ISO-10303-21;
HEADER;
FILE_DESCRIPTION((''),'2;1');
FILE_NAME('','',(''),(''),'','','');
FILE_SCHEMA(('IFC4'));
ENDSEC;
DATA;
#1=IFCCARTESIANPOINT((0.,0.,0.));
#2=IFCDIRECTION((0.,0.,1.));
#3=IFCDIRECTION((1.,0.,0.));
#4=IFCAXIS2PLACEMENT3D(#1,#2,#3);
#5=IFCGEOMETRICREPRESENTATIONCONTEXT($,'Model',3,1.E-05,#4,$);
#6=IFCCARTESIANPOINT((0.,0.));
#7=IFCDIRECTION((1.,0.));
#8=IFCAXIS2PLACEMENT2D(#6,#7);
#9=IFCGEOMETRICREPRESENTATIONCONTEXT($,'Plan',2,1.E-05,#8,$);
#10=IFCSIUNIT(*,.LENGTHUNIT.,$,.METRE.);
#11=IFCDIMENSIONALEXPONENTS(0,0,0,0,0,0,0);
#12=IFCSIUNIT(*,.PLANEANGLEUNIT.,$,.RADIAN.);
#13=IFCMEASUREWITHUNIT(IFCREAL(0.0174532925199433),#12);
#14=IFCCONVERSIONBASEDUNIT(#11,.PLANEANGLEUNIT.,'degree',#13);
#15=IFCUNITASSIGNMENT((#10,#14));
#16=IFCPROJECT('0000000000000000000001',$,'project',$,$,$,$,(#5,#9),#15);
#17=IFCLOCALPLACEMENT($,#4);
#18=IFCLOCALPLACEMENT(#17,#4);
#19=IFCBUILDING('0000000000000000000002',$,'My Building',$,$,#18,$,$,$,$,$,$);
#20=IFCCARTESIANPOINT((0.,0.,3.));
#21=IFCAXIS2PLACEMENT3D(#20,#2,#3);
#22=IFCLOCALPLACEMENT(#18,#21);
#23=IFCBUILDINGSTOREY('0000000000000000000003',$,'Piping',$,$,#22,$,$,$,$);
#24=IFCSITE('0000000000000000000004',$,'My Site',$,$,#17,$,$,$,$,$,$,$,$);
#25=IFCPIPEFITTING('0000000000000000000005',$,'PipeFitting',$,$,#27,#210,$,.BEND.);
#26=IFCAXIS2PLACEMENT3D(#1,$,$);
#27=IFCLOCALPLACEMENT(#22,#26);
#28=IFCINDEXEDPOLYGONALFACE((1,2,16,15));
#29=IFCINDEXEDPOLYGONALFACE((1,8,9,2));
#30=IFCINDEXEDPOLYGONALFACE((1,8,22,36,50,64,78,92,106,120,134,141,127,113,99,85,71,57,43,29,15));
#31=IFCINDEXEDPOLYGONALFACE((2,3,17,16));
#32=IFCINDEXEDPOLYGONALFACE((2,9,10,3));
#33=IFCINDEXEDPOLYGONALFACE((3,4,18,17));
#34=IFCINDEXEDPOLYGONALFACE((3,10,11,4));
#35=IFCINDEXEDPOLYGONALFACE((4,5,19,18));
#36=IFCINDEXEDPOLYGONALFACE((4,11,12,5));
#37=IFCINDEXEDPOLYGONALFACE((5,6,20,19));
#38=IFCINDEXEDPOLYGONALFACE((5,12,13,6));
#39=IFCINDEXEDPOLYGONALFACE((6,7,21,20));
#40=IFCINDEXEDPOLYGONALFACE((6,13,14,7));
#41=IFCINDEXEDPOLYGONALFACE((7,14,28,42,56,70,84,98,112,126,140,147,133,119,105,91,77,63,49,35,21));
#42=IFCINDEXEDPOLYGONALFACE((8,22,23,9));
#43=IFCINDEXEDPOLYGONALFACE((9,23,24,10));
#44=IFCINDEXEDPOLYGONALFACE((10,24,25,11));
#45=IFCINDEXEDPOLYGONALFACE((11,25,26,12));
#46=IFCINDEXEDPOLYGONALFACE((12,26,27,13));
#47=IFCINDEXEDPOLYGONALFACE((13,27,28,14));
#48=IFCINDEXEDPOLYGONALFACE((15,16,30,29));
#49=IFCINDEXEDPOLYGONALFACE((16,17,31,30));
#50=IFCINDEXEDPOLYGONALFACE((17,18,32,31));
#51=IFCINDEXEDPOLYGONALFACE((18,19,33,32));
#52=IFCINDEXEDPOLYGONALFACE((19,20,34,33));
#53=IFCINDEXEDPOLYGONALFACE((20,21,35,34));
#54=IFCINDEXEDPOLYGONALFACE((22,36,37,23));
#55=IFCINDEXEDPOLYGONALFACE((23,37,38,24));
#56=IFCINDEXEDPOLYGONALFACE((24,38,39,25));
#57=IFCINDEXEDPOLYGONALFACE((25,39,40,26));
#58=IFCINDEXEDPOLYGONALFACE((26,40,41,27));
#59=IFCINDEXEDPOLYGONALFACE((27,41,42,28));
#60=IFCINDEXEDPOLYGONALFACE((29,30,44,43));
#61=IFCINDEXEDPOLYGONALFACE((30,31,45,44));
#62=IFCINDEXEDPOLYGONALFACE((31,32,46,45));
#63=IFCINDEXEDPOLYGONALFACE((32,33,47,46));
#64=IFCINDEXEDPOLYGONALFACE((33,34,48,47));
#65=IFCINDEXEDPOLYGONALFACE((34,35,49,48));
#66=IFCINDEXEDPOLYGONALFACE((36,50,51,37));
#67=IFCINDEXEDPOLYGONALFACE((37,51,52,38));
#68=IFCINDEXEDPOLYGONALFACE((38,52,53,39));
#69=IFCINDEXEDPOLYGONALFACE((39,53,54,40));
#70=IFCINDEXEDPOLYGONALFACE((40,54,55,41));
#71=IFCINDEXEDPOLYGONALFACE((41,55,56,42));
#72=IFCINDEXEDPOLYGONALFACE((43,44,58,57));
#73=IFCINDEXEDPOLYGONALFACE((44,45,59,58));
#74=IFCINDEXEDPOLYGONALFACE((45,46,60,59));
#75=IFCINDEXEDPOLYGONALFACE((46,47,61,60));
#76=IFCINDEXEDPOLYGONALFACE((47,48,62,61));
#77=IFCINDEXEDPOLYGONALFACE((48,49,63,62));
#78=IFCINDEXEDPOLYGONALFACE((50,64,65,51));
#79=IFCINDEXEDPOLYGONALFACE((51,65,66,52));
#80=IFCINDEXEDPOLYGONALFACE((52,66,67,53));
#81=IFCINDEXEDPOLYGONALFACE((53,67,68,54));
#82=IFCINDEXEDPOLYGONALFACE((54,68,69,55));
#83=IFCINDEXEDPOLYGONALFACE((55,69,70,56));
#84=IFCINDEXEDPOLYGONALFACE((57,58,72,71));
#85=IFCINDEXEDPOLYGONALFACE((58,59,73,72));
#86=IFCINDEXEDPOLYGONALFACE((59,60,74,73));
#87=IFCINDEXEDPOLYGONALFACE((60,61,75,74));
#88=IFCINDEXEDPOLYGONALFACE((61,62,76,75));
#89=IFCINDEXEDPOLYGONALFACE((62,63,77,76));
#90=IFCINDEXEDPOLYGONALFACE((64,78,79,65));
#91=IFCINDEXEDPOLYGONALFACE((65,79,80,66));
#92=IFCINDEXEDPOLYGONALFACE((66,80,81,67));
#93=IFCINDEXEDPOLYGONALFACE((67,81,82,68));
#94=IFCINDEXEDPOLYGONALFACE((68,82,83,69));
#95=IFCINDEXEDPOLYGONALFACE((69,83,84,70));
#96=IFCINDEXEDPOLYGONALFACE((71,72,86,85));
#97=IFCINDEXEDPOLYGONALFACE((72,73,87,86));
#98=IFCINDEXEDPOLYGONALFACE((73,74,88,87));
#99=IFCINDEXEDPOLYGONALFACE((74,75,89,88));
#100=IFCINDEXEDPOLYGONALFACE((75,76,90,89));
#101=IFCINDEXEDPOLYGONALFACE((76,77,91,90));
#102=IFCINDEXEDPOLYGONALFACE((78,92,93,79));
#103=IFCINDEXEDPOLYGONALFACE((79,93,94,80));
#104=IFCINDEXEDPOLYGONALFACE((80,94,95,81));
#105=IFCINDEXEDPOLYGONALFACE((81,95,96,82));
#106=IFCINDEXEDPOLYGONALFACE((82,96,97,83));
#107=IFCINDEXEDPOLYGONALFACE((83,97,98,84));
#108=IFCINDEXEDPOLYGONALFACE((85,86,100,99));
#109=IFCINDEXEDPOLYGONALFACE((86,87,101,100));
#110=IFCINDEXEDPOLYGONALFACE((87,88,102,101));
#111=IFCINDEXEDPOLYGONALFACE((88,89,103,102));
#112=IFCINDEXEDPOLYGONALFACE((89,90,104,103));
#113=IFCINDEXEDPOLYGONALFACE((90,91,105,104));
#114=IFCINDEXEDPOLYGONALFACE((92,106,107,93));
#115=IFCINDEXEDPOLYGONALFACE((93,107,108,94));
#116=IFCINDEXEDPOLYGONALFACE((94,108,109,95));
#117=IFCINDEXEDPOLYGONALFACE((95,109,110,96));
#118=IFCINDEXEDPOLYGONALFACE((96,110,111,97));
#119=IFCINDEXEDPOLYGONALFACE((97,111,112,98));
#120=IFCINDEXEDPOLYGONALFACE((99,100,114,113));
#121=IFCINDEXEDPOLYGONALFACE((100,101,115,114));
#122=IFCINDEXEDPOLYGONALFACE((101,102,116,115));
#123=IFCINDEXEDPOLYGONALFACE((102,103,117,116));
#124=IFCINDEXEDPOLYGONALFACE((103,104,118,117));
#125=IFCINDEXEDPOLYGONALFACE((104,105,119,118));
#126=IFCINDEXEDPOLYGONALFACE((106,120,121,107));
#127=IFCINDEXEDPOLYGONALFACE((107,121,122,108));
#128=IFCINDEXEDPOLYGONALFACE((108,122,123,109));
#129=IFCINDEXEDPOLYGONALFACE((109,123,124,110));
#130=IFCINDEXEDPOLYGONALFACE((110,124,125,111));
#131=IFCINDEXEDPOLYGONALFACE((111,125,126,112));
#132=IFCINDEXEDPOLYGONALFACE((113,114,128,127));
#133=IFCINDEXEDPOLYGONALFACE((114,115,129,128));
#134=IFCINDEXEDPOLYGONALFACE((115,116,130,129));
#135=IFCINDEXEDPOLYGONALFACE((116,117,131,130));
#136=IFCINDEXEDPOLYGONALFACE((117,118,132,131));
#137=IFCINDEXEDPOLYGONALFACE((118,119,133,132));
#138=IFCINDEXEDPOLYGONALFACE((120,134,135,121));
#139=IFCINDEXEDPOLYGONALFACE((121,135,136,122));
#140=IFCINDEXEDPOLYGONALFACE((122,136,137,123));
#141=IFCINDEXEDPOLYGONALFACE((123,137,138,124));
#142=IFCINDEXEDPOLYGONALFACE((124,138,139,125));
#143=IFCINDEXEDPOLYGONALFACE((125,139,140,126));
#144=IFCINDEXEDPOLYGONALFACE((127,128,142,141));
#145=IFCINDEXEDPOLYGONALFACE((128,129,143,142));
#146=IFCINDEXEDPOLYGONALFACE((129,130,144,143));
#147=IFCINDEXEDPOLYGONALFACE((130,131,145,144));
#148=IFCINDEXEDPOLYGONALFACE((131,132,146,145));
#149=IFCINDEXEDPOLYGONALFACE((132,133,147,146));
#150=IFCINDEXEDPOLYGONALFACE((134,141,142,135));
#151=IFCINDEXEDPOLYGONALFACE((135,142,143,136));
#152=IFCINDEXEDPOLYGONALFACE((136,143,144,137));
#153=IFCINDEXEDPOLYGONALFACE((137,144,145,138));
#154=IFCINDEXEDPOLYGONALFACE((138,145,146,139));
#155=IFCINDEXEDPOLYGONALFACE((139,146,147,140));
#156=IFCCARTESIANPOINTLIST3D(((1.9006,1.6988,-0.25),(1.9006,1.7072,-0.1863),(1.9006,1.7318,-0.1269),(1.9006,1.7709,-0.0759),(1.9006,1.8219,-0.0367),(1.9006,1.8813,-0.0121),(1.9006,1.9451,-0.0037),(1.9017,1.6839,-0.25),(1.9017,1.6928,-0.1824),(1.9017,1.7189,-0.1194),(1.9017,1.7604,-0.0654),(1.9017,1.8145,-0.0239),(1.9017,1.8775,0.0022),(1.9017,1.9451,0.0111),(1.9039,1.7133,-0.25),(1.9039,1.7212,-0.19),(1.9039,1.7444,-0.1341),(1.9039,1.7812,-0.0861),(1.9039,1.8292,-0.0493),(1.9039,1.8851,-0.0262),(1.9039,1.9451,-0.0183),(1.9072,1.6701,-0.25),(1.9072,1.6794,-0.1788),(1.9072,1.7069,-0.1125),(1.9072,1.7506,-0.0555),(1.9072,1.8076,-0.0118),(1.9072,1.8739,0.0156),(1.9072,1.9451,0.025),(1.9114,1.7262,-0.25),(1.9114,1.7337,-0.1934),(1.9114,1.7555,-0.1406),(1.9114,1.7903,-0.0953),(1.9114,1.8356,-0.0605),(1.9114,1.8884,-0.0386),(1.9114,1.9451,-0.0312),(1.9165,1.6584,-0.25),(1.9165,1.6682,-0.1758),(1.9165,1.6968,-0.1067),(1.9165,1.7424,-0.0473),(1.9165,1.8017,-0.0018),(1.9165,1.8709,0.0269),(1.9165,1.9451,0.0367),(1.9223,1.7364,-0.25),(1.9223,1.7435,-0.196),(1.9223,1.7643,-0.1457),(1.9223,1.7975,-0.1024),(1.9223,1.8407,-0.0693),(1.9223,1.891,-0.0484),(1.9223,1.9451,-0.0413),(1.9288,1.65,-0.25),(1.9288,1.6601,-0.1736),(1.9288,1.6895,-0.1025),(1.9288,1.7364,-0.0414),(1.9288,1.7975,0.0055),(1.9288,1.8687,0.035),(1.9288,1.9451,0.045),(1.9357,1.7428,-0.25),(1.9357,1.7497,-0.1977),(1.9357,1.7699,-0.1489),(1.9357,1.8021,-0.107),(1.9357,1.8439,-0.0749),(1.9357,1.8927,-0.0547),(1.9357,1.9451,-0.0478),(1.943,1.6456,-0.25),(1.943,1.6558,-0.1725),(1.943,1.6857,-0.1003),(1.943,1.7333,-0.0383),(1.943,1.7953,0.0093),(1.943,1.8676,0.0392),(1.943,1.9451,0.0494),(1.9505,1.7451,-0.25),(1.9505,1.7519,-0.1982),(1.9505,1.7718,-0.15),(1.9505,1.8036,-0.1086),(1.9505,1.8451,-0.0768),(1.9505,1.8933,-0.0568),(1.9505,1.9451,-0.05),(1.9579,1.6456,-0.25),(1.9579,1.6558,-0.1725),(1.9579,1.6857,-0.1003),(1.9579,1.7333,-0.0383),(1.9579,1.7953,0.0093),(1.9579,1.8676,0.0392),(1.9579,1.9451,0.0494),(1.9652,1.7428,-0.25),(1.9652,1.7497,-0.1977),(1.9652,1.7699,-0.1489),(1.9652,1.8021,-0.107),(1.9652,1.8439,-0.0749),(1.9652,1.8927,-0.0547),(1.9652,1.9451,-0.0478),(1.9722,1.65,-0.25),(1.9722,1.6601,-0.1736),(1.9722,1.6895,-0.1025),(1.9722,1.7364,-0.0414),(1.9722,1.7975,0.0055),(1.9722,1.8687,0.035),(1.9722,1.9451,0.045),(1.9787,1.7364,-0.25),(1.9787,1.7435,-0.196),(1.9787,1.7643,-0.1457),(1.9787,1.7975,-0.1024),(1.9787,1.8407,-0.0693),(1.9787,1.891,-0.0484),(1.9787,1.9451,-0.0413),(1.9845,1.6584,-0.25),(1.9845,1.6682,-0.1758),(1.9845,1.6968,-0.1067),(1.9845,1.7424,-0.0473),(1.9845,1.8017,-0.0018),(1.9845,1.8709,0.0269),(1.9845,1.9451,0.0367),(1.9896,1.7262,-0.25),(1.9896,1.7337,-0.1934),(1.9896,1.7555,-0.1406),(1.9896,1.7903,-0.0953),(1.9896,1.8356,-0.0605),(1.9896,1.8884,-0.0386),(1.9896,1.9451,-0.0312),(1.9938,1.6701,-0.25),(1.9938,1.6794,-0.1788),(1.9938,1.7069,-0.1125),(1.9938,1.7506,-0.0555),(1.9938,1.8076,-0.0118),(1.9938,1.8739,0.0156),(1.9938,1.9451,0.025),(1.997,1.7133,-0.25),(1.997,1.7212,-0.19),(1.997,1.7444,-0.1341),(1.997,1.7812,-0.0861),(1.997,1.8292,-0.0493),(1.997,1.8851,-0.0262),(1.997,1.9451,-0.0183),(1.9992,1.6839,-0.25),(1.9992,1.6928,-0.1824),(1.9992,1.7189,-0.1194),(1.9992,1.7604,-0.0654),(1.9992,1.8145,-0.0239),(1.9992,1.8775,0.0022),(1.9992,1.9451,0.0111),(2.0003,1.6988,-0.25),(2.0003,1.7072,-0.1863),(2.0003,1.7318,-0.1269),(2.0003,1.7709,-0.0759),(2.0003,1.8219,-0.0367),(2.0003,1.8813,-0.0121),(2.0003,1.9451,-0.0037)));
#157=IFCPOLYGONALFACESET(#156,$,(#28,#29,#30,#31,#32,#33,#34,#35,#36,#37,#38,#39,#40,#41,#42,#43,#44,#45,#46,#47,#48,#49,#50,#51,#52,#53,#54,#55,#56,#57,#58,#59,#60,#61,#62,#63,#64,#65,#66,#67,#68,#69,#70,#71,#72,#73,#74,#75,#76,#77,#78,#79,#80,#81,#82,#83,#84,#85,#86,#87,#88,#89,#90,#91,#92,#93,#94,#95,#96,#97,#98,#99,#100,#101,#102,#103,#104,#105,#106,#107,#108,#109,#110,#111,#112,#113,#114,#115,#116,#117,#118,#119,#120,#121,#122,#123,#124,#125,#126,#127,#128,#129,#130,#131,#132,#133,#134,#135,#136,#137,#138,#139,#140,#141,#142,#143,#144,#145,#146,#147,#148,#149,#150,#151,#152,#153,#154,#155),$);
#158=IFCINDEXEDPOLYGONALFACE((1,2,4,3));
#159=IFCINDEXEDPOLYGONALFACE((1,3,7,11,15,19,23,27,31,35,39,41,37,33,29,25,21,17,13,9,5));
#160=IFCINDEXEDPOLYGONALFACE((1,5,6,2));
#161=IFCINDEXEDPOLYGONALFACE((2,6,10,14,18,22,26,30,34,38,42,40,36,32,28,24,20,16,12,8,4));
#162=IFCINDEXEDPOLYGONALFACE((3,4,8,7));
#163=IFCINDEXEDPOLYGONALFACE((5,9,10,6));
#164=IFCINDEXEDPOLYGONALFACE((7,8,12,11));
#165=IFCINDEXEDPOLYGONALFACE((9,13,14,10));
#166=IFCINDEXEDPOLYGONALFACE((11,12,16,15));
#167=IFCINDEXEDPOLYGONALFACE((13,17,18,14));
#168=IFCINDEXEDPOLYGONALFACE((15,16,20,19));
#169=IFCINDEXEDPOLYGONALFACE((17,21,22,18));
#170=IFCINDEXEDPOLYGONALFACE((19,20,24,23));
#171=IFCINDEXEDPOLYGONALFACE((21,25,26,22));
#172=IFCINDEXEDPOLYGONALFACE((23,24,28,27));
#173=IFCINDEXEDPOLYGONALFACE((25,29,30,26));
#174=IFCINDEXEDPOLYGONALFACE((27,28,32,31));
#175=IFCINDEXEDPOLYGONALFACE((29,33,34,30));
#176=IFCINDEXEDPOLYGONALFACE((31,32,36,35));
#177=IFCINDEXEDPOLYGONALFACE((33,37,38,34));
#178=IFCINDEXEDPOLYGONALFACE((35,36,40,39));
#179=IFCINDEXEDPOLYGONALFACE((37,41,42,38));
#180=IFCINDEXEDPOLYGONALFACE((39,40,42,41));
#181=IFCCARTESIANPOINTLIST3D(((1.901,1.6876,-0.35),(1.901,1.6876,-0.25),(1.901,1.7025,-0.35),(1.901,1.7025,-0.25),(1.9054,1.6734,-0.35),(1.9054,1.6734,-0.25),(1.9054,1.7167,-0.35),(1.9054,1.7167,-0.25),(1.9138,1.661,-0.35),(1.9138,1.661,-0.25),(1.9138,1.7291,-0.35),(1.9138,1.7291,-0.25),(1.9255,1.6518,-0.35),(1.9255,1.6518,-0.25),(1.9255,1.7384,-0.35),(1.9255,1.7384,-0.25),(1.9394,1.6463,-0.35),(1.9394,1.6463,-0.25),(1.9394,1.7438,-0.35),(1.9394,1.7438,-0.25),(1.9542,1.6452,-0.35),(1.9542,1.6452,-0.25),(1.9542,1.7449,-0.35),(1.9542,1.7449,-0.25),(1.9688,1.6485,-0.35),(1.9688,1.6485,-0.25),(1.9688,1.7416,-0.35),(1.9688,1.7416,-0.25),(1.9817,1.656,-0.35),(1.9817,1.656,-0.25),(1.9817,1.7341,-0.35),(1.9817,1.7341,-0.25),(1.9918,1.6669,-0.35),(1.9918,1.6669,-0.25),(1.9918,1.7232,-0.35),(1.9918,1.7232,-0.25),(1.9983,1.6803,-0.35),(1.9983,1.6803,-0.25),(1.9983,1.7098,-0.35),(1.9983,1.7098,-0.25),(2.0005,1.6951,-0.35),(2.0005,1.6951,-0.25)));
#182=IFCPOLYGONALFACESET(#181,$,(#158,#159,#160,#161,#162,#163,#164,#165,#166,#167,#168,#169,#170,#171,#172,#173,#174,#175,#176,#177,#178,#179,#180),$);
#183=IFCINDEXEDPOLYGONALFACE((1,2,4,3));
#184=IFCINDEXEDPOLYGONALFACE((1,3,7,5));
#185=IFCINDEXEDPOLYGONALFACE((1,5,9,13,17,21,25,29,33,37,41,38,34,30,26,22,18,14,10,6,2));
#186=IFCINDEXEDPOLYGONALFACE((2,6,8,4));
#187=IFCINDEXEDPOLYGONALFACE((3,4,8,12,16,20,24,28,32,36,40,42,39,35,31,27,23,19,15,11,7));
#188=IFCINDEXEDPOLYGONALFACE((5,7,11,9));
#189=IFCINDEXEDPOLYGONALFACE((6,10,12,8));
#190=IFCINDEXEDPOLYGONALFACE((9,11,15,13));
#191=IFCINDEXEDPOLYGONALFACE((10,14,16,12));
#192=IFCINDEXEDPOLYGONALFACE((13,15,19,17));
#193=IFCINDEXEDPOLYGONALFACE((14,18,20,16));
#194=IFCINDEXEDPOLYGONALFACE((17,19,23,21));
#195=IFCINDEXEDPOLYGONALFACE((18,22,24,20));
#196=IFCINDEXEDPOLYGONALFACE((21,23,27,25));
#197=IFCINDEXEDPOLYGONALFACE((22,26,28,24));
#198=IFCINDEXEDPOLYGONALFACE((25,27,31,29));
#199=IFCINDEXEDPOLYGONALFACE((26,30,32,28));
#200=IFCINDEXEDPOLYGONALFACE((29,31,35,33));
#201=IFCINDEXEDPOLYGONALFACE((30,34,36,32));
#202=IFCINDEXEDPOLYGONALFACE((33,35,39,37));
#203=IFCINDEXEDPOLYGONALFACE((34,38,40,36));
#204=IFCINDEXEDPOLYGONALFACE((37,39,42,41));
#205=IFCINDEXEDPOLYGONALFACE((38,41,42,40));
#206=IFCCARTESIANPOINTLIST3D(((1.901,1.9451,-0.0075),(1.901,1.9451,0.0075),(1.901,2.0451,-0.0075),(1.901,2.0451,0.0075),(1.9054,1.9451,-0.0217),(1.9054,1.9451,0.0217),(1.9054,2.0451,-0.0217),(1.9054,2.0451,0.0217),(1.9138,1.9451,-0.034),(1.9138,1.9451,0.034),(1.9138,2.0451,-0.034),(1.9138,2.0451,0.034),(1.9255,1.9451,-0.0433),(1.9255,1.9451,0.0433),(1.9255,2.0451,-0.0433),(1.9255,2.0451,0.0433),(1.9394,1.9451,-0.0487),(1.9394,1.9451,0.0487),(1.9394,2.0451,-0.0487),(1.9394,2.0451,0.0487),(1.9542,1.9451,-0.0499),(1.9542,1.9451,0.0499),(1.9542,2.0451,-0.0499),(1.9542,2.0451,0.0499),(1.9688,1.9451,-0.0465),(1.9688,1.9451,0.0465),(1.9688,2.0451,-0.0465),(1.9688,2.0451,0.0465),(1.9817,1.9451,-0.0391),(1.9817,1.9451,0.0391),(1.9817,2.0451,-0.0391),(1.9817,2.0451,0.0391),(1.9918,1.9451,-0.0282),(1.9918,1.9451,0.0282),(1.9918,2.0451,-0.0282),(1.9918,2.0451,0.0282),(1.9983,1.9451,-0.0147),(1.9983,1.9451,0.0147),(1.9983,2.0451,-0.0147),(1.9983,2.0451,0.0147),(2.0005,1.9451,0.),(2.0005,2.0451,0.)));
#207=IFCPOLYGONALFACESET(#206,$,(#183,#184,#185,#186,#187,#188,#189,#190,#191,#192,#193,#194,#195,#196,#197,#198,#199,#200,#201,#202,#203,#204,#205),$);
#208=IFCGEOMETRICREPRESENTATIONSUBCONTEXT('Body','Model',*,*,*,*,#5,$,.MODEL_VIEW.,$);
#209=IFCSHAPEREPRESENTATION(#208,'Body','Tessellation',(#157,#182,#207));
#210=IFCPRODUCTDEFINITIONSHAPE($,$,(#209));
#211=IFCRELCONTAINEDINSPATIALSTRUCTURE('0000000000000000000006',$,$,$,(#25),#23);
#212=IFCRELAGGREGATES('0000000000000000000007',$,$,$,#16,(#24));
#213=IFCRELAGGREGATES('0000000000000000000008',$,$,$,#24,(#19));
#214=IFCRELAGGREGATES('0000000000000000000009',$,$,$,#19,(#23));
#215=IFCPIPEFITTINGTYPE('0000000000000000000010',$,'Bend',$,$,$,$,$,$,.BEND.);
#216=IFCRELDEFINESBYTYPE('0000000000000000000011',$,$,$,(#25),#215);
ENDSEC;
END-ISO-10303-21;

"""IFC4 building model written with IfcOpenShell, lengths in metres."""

from ifc_helpers import new_model, entity, si_unit, converted_unit, frame, origin_with_axes, origin_2d_with_axis, place, context, subcontext, project, spatial, circle, extrude, source, transform, mapped, type_object, type_shapes, element, save


model = new_model("IFC4")

# Units and contexts
model_context = context("Model", 3, precision=1e-05, world=origin_with_axes())
plan_context = context("Plan", 2, precision=1e-05, world=origin_2d_with_axis())
body_context = subcontext(model_context, "Body", "Model", "MODEL_VIEW")
ifc_project = project(units=[si_unit("LENGTHUNIT", "METRE"), converted_unit("PLANEANGLEUNIT", "degree", entity("IfcReal", 0.0174532925199433), si_unit("PLANEANGLEUNIT", "RADIAN"), dimensions=[0, 0, 0, 0, 0, 0, 0])], contexts=[model_context, plan_context])

# Site, building, storey
site_placement = place(None, origin_with_axes())
site = spatial("IfcSite", under=ifc_project, at=site_placement, Name="My Site")
building_placement = place(site_placement, origin_with_axes())
building = spatial("IfcBuilding", under=site, at=building_placement, Name="My Building")
storey_placement = place(building_placement, frame((0.0, 0.0, 3.0), z_axis=(0.0, 0.0, 1.0), x_axis=(1.0, 0.0, 0.0)))
storey = spatial("IfcBuildingStorey", under=building, at=storey_placement, Name="Piping")

# Pipe fitting
pipe_fitting_type = type_object("IfcPipeFittingType", Name="Bend", PredefinedType="BEND")
shared_shape = source(origin_with_axes(), body_context, "Body", "SolidModel", [
    entity("IfcSweptDiskSolid", entity("IfcIndexedPolyCurve", entity("IfcCartesianPointList3D", [[0.0, 0.0, -0.1], [0.0, -0.0732, -0.2768], [0.0, -0.25, -0.35]]), [entity("IfcArcIndex", [1, 2, 3])]), 0.05),
    extrude(circle(Radius=0.05), origin_with_axes(), (0.0, 0.0, -1.0), 0.1),
    extrude(circle(Radius=0.05), frame((0.0, -0.25, -0.35), z_axis=(0.0, -1.0, 0.0), x_axis=(1.0, 0.0, 0.0)), (0.0, 0.0, 1.0), 0.1),
])
type_shapes(pipe_fitting_type, [shared_shape])
for number, where, z_axis, x_axis, name in (
    (1, (1.9505, 1.6951, -0.35), (0.0, 0.0, -1.0), (1.0, 0.0, 0.0), "PipeFitting"),
):
    element("IfcPipeFitting", number, at=place(storey_placement, frame(where, z_axis=z_axis, x_axis=x_axis)), inside=storey, type_object=pipe_fitting_type, Name=name, PredefinedType="BEND", context=body_context, shape_type="MappedRepresentation", body=[
        mapped(shared_shape, transform((0.0, 0.0, 0.0), x_axis=(1.0, 0.0, 0.0), y_axis=(0.0, 1.0, 0.0), z_axis=(0.0, 0.0, 1.0), scale=1.0)),
    ])

save(model, "model.ifc")
